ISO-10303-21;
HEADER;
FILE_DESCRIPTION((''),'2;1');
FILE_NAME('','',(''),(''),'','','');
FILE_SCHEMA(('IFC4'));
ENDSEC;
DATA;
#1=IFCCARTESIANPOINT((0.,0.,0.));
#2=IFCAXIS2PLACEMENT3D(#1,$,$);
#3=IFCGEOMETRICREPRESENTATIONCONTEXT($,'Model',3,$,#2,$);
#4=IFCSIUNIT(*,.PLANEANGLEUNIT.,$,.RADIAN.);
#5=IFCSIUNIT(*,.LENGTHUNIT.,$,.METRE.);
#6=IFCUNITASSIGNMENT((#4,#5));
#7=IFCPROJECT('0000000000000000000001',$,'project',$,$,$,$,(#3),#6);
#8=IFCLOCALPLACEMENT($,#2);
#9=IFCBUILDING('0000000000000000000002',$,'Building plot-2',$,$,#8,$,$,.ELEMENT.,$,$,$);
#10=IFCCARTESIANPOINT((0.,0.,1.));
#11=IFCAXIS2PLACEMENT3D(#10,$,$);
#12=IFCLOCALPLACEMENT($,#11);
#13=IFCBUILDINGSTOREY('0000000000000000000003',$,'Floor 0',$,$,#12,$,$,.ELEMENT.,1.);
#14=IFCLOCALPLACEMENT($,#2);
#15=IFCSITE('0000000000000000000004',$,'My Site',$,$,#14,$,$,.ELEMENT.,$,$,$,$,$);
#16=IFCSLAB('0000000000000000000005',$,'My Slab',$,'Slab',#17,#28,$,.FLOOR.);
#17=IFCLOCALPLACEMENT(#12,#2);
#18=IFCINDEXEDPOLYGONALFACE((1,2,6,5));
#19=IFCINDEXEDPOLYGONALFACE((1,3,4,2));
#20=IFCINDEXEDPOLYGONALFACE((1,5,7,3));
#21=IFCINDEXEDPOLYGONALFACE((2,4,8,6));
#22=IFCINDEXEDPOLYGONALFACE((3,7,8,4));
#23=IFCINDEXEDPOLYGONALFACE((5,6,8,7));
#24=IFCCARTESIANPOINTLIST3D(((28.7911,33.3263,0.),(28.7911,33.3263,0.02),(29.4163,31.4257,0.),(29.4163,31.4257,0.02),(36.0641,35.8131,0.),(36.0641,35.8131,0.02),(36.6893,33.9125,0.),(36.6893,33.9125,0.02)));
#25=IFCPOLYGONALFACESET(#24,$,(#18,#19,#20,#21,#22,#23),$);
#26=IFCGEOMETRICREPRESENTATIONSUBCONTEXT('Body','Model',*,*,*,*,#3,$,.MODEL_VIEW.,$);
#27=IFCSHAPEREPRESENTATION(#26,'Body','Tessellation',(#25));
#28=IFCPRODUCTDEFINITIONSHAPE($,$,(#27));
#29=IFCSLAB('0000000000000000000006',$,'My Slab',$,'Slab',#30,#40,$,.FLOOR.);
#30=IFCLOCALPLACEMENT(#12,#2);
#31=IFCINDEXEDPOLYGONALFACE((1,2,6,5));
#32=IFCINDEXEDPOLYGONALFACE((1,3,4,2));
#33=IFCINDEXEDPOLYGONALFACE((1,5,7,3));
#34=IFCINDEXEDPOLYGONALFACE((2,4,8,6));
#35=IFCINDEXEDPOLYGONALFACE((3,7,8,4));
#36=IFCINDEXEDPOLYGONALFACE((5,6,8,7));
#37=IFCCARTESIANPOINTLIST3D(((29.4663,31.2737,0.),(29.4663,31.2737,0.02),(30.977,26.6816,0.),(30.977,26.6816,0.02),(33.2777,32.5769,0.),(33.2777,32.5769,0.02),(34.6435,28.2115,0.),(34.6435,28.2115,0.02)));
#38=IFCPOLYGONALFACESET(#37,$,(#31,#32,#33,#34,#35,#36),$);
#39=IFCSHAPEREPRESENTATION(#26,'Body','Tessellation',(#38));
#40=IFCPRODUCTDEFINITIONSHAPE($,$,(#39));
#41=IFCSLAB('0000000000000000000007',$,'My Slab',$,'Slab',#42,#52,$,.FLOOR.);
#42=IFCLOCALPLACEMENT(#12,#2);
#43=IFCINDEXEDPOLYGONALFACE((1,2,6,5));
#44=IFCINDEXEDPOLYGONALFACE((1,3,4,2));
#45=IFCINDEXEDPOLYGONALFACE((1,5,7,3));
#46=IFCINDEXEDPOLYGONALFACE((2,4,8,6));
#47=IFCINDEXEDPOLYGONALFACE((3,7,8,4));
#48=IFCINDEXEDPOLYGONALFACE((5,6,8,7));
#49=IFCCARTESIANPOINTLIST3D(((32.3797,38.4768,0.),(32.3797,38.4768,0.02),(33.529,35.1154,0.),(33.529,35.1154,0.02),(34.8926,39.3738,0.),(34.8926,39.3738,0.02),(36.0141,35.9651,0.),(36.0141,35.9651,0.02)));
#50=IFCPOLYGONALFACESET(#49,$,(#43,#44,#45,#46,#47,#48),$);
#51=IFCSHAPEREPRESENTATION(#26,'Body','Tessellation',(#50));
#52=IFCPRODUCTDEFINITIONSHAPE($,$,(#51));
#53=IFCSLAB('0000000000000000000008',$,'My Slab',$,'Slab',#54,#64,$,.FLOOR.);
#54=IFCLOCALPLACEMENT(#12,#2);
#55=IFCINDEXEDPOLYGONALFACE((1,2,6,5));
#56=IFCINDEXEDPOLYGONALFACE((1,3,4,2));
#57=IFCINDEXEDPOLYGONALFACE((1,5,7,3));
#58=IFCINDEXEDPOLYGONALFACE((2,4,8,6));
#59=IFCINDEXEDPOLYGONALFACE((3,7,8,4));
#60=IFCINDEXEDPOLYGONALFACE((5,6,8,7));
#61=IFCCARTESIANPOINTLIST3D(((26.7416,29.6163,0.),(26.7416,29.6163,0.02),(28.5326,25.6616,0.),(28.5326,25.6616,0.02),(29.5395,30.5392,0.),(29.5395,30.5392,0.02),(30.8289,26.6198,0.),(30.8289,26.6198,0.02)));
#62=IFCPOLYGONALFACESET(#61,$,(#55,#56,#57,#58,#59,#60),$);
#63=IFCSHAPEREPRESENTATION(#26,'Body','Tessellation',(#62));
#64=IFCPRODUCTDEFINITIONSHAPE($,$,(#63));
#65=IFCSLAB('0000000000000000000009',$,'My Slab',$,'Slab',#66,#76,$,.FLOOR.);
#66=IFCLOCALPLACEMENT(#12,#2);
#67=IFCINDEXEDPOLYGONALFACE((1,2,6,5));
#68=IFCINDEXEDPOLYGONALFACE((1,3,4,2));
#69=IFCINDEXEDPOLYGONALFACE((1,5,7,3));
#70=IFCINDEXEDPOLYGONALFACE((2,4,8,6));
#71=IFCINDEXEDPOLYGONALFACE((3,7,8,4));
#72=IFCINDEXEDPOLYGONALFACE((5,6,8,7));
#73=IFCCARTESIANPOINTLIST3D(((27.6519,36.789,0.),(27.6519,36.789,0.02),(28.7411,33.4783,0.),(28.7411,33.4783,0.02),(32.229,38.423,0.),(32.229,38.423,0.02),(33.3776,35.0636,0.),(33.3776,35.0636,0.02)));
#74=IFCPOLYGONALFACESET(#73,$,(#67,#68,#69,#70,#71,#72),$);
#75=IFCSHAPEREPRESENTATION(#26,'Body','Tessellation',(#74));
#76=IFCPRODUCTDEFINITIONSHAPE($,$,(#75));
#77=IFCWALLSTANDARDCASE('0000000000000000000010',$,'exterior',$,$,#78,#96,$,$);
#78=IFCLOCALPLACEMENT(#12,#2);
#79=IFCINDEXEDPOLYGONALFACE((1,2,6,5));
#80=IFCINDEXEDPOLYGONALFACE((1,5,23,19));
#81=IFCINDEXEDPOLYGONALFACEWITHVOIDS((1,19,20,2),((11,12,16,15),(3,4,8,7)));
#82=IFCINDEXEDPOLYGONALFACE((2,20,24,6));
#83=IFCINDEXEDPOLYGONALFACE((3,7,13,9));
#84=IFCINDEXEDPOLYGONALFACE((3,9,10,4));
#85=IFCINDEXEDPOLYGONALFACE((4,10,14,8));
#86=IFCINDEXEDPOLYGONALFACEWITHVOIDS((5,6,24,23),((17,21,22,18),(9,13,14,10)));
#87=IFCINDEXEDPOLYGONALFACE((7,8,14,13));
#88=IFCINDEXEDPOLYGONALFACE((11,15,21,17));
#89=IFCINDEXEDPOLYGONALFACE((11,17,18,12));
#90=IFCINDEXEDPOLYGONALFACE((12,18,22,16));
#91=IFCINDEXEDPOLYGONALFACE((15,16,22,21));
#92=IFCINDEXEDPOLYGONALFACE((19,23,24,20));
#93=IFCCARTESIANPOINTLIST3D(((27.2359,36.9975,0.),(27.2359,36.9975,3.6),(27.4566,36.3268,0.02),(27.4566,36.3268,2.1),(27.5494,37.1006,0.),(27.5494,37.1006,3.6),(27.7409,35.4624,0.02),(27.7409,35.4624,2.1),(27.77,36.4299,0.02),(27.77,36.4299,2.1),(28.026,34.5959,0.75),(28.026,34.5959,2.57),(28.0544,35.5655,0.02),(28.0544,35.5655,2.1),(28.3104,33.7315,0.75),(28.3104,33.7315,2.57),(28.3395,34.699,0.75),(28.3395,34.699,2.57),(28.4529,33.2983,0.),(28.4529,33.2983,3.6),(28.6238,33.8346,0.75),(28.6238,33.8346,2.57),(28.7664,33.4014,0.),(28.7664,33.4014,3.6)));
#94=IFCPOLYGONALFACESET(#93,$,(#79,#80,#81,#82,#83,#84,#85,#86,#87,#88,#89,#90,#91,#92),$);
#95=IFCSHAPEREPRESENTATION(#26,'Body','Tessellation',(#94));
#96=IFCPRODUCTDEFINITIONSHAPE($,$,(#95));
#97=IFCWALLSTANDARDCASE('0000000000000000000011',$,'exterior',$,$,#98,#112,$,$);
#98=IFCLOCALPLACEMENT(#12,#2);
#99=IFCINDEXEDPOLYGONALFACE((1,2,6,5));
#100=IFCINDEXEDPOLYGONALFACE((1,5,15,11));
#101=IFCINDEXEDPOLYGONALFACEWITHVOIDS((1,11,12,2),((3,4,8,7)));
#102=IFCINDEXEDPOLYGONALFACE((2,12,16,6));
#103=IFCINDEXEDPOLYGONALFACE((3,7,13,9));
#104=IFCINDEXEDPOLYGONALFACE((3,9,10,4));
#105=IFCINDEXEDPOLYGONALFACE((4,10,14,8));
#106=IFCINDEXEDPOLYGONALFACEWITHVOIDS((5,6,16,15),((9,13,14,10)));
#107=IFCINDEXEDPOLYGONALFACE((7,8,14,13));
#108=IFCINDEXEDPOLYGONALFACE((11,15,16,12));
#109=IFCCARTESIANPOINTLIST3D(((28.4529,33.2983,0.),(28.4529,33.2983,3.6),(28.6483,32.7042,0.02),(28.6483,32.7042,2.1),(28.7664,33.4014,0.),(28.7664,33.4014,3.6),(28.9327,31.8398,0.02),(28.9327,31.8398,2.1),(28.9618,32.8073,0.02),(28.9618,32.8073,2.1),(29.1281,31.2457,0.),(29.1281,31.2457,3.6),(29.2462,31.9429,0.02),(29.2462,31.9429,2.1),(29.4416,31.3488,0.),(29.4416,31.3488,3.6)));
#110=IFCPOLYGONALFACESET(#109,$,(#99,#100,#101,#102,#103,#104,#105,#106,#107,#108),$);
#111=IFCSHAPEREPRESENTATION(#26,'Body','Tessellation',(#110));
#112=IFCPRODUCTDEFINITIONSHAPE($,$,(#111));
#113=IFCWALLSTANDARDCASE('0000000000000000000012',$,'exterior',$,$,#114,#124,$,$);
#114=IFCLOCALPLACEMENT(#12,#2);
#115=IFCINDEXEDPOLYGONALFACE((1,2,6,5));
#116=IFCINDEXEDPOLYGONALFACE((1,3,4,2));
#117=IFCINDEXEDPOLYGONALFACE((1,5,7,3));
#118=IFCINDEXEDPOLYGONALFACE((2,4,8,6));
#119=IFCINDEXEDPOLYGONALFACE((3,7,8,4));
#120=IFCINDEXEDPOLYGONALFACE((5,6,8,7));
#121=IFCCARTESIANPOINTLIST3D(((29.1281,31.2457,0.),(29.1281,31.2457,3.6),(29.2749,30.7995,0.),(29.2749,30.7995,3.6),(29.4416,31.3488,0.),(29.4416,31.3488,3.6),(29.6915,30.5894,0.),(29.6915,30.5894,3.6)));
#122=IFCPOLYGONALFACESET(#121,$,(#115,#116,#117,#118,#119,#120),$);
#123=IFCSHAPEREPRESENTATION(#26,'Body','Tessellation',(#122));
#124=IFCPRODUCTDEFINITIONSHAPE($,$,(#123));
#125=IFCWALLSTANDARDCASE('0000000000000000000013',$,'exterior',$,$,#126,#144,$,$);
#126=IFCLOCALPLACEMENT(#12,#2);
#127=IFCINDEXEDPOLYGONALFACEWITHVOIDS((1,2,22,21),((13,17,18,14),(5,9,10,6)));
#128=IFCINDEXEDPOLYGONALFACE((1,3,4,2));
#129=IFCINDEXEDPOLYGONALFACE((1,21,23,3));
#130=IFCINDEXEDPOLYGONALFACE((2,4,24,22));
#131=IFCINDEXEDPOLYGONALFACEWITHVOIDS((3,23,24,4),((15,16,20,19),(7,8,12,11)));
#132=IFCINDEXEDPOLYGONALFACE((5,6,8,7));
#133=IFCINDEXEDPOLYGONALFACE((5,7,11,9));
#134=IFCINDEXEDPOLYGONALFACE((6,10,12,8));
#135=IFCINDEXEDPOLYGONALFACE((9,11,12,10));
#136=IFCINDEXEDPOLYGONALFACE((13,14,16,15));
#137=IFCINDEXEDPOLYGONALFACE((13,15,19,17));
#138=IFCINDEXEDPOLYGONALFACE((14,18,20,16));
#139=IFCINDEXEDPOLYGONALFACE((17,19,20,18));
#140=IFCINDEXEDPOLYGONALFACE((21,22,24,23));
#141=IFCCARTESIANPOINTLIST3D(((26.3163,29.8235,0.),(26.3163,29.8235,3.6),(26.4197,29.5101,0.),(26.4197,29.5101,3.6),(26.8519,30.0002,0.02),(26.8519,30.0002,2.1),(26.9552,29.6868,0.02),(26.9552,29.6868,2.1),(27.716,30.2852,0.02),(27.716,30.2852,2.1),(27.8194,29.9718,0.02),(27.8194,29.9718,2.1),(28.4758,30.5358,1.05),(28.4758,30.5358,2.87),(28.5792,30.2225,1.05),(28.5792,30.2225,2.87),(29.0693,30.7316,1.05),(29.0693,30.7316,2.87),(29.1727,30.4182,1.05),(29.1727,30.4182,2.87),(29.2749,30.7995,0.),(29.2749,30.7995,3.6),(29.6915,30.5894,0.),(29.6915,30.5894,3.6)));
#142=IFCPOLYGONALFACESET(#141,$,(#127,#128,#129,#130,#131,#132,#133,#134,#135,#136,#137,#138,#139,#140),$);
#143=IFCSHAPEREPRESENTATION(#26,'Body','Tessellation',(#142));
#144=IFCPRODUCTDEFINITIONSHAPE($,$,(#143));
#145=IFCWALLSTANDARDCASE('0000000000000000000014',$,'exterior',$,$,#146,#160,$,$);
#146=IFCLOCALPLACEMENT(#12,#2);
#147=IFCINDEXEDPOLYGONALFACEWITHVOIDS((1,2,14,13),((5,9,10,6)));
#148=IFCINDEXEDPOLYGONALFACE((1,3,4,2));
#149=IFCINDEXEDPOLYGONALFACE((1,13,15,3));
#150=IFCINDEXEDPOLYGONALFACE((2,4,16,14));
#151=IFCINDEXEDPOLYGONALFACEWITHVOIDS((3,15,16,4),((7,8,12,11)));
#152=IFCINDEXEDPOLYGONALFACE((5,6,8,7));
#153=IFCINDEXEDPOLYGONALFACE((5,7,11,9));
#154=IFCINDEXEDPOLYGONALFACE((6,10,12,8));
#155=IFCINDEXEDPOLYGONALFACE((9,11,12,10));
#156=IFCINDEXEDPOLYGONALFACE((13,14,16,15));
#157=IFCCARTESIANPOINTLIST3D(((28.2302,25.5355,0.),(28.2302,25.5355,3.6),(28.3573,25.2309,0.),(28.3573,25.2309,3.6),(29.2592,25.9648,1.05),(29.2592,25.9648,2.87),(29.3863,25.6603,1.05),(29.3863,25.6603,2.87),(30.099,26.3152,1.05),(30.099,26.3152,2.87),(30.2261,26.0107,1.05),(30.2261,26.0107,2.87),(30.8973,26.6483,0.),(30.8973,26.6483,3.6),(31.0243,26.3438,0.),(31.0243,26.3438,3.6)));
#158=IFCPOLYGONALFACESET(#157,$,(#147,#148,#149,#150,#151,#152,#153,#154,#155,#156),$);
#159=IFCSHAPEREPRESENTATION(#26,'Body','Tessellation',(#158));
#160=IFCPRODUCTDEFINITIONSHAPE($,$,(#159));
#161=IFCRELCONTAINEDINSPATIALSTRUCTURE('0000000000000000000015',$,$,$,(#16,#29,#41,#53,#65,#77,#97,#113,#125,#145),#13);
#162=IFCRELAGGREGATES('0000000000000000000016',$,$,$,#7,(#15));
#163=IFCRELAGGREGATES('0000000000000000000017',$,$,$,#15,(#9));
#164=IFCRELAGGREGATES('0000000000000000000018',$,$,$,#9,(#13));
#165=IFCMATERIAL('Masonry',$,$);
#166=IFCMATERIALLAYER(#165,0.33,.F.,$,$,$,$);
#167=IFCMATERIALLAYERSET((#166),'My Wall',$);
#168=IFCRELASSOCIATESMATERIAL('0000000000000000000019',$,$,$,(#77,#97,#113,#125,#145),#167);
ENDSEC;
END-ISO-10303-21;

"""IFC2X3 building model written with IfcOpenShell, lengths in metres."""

from ifc_helpers import new_model, si_unit, frame, origin, place, context, subcontext, project, spatial, polyline, outline, extrude, material, layer, layer_set, layer_usage, element, save


model = new_model("IFC2X3")

# Units and contexts
model_context = context("Model", 3, world=origin())
body_context = subcontext(model_context, "Body", "Model", "MODEL_VIEW")
ifc_project = project(units=[si_unit("PLANEANGLEUNIT", "RADIAN"), si_unit("LENGTHUNIT", "METRE")], contexts=[model_context])

# Site, building, storey
site_placement = place(None, origin())
site = spatial("IfcSite", under=ifc_project, at=site_placement, Name="My Site", CompositionType="ELEMENT")
building_placement = place(None, origin())
building = spatial("IfcBuilding", under=site, at=building_placement, Name="Building plot-2", CompositionType="ELEMENT")
storey_placement = place(None, frame((0.0, 0.0, 1.0)))
storey = spatial("IfcBuildingStorey", under=building, at=storey_placement, Name="Floor 0", CompositionType="ELEMENT", Elevation=1.0)

# Slabs
slab_1_placement = place(storey_placement, origin())
element("IfcSlab", 1, at=slab_1_placement, inside=storey, Name="My Slab", ObjectType="Slab", PredefinedType="FLOOR", context=body_context, shape_type="SweptSolid", body=[
    extrude(outline(polyline([(28.7911, 33.3263), (29.4163, 31.4257), (36.6893, 33.9125), (36.0641, 35.8131), (28.7911, 33.3263)])), origin(), (0.0, 0.0, 1.0), 0.02),
])
slab_2_placement = place(storey_placement, origin())
element("IfcSlab", 2, at=slab_2_placement, inside=storey, Name="My Slab", ObjectType="Slab", PredefinedType="FLOOR", context=body_context, shape_type="SweptSolid", body=[
    extrude(outline(polyline([(30.977, 26.6816), (34.6435, 28.2115), (33.2777, 32.5769), (29.4663, 31.2737), (30.977, 26.6816)])), origin(), (0.0, 0.0, 1.0), 0.02),
])
slab_3_placement = place(storey_placement, origin())
element("IfcSlab", 3, at=slab_3_placement, inside=storey, Name="My Slab", ObjectType="Slab", PredefinedType="FLOOR", context=body_context, shape_type="SweptSolid", body=[
    extrude(outline(polyline([(33.529, 35.1154), (36.0141, 35.9651), (34.8926, 39.3738), (32.3797, 38.4768), (33.529, 35.1154)])), origin(), (0.0, 0.0, 1.0), 0.02),
])
slab_4_placement = place(storey_placement, origin())
element("IfcSlab", 4, at=slab_4_placement, inside=storey, Name="My Slab", ObjectType="Slab", PredefinedType="FLOOR", context=body_context, shape_type="SweptSolid", body=[
    extrude(outline(polyline([(26.7416, 29.6163), (28.5326, 25.6616), (30.8289, 26.6198), (29.5395, 30.5392), (26.7416, 29.6163)])), origin(), (0.0, 0.0, 1.0), 0.02),
])
slab_5_placement = place(storey_placement, origin())
element("IfcSlab", 5, at=slab_5_placement, inside=storey, Name="My Slab", ObjectType="Slab", PredefinedType="FLOOR", context=body_context, shape_type="SweptSolid", body=[
    extrude(outline(polyline([(28.7411, 33.4783), (33.3776, 35.0636), (32.229, 38.423), (27.6519, 36.789), (28.7411, 33.4783)])), origin(), (0.0, 0.0, 1.0), 0.02),
])

# Wall, openings
ifc_material = material(Name="Masonry")
ifc_layer = layer(ifc_material, 0.33, ventilated=False)
ifc_layer_set = layer_set([ifc_layer], Name="My Wall")
ifc_layer_usage = layer_usage(ifc_layer_set, "AXIS2", "NEGATIVE", 0.08)
wall_1_placement = place(storey_placement, origin())
wall_1 = element("IfcWallStandardCase", 6, at=wall_1_placement, inside=storey, material=ifc_layer_usage, Name="exterior", context=body_context, shape_type="SweptSolid", body=[
    extrude(outline(polyline([(27.5494, 37.1006), (27.2359, 36.9975), (28.4529, 33.2983), (28.7664, 33.4014), (27.5494, 37.1006)])), origin(), (0.0, 0.0, 1.0), 3.6),
])
opening_1_placement = place(storey_placement, frame((0.0, 0.0, 0.02)))
element("IfcOpeningElement", 7, at=opening_1_placement, cuts=wall_1, ObjectType="Opening", context=body_context, shape_type="SweptSolid", body=[
    extrude(outline(polyline([(27.4566, 36.3268), (27.7409, 35.4624), (28.0544, 35.5655), (27.77, 36.4299), (27.4566, 36.3268)])), origin(), (0.0, 0.0, 1.0), 2.08),
])
opening_2_placement = place(storey_placement, frame((0.0, 0.0, 0.75)))
element("IfcOpeningElement", 8, at=opening_2_placement, cuts=wall_1, ObjectType="Opening", context=body_context, shape_type="SweptSolid", body=[
    extrude(outline(polyline([(28.026, 34.5959), (28.3104, 33.7315), (28.6238, 33.8346), (28.3395, 34.699), (28.026, 34.5959)])), origin(), (0.0, 0.0, 1.0), 1.82),
])

# Wall, opening
wall_2_placement = place(storey_placement, origin())
wall_2 = element("IfcWallStandardCase", 9, at=wall_2_placement, inside=storey, material=ifc_layer_usage, Name="exterior", context=body_context, shape_type="SweptSolid", body=[
    extrude(outline(polyline([(28.7664, 33.4014), (28.4529, 33.2983), (29.1281, 31.2457), (29.4416, 31.3488), (28.7664, 33.4014)])), origin(), (0.0, 0.0, 1.0), 3.6),
])
opening_3_placement = place(storey_placement, frame((0.0, 0.0, 0.02)))
element("IfcOpeningElement", 10, at=opening_3_placement, cuts=wall_2, ObjectType="Opening", context=body_context, shape_type="SweptSolid", body=[
    extrude(outline(polyline([(28.6483, 32.7042), (28.9327, 31.8398), (29.2462, 31.9429), (28.9618, 32.8073), (28.6483, 32.7042)])), origin(), (0.0, 0.0, 1.0), 2.08),
])

# Wall
wall_3_placement = place(storey_placement, origin())
element("IfcWallStandardCase", 11, at=wall_3_placement, inside=storey, material=ifc_layer_usage, Name="exterior", context=body_context, shape_type="SweptSolid", body=[
    extrude(outline(polyline([(29.4416, 31.3488), (29.1281, 31.2457), (29.2749, 30.7995), (29.6915, 30.5894), (29.4416, 31.3488)])), origin(), (0.0, 0.0, 1.0), 3.6),
])

# Wall, openings
wall_4_placement = place(storey_placement, origin())
wall_4 = element("IfcWallStandardCase", 12, at=wall_4_placement, inside=storey, material=ifc_layer_usage, Name="exterior", context=body_context, shape_type="SweptSolid", body=[
    extrude(outline(polyline([(29.6915, 30.5894), (29.2749, 30.7995), (26.3163, 29.8235), (26.4197, 29.5101), (29.6915, 30.5894)])), origin(), (0.0, 0.0, 1.0), 3.6),
])
opening_4_placement = place(storey_placement, frame((0.0, 0.0, 1.05)))
element("IfcOpeningElement", 13, at=opening_4_placement, cuts=wall_4, ObjectType="Opening", context=body_context, shape_type="SweptSolid", body=[
    extrude(outline(polyline([(29.0693, 30.7316), (28.4758, 30.5358), (28.5792, 30.2225), (29.1727, 30.4182), (29.0693, 30.7316)])), origin(), (0.0, 0.0, 1.0), 1.82),
])
opening_5_placement = place(storey_placement, frame((0.0, 0.0, 0.02)))
element("IfcOpeningElement", 14, at=opening_5_placement, cuts=wall_4, ObjectType="Opening", context=body_context, shape_type="SweptSolid", body=[
    extrude(outline(polyline([(27.716, 30.2852), (26.8519, 30.0002), (26.9552, 29.6868), (27.8194, 29.9718), (27.716, 30.2852)])), origin(), (0.0, 0.0, 1.0), 2.08),
])

# Wall, opening
wall_5_placement = place(storey_placement, origin())
wall_5 = element("IfcWallStandardCase", 15, at=wall_5_placement, inside=storey, material=ifc_layer_usage, Name="exterior", context=body_context, shape_type="SweptSolid", body=[
    extrude(outline(polyline([(28.2302, 25.5355), (28.3573, 25.2309), (31.0243, 26.3438), (30.8973, 26.6483), (28.2302, 25.5355)])), origin(), (0.0, 0.0, 1.0), 3.6),
])
opening_6_placement = place(storey_placement, frame((0.0, 0.0, 1.05)))
element("IfcOpeningElement", 16, at=opening_6_placement, cuts=wall_5, ObjectType="Opening", context=body_context, shape_type="SweptSolid", body=[
    extrude(outline(polyline([(29.3863, 25.6603), (30.2261, 26.0107), (30.099, 26.3152), (29.2592, 25.9648), (29.3863, 25.6603)])), origin(), (0.0, 0.0, 1.0), 1.82),
])

save(model, "model.ifc")
